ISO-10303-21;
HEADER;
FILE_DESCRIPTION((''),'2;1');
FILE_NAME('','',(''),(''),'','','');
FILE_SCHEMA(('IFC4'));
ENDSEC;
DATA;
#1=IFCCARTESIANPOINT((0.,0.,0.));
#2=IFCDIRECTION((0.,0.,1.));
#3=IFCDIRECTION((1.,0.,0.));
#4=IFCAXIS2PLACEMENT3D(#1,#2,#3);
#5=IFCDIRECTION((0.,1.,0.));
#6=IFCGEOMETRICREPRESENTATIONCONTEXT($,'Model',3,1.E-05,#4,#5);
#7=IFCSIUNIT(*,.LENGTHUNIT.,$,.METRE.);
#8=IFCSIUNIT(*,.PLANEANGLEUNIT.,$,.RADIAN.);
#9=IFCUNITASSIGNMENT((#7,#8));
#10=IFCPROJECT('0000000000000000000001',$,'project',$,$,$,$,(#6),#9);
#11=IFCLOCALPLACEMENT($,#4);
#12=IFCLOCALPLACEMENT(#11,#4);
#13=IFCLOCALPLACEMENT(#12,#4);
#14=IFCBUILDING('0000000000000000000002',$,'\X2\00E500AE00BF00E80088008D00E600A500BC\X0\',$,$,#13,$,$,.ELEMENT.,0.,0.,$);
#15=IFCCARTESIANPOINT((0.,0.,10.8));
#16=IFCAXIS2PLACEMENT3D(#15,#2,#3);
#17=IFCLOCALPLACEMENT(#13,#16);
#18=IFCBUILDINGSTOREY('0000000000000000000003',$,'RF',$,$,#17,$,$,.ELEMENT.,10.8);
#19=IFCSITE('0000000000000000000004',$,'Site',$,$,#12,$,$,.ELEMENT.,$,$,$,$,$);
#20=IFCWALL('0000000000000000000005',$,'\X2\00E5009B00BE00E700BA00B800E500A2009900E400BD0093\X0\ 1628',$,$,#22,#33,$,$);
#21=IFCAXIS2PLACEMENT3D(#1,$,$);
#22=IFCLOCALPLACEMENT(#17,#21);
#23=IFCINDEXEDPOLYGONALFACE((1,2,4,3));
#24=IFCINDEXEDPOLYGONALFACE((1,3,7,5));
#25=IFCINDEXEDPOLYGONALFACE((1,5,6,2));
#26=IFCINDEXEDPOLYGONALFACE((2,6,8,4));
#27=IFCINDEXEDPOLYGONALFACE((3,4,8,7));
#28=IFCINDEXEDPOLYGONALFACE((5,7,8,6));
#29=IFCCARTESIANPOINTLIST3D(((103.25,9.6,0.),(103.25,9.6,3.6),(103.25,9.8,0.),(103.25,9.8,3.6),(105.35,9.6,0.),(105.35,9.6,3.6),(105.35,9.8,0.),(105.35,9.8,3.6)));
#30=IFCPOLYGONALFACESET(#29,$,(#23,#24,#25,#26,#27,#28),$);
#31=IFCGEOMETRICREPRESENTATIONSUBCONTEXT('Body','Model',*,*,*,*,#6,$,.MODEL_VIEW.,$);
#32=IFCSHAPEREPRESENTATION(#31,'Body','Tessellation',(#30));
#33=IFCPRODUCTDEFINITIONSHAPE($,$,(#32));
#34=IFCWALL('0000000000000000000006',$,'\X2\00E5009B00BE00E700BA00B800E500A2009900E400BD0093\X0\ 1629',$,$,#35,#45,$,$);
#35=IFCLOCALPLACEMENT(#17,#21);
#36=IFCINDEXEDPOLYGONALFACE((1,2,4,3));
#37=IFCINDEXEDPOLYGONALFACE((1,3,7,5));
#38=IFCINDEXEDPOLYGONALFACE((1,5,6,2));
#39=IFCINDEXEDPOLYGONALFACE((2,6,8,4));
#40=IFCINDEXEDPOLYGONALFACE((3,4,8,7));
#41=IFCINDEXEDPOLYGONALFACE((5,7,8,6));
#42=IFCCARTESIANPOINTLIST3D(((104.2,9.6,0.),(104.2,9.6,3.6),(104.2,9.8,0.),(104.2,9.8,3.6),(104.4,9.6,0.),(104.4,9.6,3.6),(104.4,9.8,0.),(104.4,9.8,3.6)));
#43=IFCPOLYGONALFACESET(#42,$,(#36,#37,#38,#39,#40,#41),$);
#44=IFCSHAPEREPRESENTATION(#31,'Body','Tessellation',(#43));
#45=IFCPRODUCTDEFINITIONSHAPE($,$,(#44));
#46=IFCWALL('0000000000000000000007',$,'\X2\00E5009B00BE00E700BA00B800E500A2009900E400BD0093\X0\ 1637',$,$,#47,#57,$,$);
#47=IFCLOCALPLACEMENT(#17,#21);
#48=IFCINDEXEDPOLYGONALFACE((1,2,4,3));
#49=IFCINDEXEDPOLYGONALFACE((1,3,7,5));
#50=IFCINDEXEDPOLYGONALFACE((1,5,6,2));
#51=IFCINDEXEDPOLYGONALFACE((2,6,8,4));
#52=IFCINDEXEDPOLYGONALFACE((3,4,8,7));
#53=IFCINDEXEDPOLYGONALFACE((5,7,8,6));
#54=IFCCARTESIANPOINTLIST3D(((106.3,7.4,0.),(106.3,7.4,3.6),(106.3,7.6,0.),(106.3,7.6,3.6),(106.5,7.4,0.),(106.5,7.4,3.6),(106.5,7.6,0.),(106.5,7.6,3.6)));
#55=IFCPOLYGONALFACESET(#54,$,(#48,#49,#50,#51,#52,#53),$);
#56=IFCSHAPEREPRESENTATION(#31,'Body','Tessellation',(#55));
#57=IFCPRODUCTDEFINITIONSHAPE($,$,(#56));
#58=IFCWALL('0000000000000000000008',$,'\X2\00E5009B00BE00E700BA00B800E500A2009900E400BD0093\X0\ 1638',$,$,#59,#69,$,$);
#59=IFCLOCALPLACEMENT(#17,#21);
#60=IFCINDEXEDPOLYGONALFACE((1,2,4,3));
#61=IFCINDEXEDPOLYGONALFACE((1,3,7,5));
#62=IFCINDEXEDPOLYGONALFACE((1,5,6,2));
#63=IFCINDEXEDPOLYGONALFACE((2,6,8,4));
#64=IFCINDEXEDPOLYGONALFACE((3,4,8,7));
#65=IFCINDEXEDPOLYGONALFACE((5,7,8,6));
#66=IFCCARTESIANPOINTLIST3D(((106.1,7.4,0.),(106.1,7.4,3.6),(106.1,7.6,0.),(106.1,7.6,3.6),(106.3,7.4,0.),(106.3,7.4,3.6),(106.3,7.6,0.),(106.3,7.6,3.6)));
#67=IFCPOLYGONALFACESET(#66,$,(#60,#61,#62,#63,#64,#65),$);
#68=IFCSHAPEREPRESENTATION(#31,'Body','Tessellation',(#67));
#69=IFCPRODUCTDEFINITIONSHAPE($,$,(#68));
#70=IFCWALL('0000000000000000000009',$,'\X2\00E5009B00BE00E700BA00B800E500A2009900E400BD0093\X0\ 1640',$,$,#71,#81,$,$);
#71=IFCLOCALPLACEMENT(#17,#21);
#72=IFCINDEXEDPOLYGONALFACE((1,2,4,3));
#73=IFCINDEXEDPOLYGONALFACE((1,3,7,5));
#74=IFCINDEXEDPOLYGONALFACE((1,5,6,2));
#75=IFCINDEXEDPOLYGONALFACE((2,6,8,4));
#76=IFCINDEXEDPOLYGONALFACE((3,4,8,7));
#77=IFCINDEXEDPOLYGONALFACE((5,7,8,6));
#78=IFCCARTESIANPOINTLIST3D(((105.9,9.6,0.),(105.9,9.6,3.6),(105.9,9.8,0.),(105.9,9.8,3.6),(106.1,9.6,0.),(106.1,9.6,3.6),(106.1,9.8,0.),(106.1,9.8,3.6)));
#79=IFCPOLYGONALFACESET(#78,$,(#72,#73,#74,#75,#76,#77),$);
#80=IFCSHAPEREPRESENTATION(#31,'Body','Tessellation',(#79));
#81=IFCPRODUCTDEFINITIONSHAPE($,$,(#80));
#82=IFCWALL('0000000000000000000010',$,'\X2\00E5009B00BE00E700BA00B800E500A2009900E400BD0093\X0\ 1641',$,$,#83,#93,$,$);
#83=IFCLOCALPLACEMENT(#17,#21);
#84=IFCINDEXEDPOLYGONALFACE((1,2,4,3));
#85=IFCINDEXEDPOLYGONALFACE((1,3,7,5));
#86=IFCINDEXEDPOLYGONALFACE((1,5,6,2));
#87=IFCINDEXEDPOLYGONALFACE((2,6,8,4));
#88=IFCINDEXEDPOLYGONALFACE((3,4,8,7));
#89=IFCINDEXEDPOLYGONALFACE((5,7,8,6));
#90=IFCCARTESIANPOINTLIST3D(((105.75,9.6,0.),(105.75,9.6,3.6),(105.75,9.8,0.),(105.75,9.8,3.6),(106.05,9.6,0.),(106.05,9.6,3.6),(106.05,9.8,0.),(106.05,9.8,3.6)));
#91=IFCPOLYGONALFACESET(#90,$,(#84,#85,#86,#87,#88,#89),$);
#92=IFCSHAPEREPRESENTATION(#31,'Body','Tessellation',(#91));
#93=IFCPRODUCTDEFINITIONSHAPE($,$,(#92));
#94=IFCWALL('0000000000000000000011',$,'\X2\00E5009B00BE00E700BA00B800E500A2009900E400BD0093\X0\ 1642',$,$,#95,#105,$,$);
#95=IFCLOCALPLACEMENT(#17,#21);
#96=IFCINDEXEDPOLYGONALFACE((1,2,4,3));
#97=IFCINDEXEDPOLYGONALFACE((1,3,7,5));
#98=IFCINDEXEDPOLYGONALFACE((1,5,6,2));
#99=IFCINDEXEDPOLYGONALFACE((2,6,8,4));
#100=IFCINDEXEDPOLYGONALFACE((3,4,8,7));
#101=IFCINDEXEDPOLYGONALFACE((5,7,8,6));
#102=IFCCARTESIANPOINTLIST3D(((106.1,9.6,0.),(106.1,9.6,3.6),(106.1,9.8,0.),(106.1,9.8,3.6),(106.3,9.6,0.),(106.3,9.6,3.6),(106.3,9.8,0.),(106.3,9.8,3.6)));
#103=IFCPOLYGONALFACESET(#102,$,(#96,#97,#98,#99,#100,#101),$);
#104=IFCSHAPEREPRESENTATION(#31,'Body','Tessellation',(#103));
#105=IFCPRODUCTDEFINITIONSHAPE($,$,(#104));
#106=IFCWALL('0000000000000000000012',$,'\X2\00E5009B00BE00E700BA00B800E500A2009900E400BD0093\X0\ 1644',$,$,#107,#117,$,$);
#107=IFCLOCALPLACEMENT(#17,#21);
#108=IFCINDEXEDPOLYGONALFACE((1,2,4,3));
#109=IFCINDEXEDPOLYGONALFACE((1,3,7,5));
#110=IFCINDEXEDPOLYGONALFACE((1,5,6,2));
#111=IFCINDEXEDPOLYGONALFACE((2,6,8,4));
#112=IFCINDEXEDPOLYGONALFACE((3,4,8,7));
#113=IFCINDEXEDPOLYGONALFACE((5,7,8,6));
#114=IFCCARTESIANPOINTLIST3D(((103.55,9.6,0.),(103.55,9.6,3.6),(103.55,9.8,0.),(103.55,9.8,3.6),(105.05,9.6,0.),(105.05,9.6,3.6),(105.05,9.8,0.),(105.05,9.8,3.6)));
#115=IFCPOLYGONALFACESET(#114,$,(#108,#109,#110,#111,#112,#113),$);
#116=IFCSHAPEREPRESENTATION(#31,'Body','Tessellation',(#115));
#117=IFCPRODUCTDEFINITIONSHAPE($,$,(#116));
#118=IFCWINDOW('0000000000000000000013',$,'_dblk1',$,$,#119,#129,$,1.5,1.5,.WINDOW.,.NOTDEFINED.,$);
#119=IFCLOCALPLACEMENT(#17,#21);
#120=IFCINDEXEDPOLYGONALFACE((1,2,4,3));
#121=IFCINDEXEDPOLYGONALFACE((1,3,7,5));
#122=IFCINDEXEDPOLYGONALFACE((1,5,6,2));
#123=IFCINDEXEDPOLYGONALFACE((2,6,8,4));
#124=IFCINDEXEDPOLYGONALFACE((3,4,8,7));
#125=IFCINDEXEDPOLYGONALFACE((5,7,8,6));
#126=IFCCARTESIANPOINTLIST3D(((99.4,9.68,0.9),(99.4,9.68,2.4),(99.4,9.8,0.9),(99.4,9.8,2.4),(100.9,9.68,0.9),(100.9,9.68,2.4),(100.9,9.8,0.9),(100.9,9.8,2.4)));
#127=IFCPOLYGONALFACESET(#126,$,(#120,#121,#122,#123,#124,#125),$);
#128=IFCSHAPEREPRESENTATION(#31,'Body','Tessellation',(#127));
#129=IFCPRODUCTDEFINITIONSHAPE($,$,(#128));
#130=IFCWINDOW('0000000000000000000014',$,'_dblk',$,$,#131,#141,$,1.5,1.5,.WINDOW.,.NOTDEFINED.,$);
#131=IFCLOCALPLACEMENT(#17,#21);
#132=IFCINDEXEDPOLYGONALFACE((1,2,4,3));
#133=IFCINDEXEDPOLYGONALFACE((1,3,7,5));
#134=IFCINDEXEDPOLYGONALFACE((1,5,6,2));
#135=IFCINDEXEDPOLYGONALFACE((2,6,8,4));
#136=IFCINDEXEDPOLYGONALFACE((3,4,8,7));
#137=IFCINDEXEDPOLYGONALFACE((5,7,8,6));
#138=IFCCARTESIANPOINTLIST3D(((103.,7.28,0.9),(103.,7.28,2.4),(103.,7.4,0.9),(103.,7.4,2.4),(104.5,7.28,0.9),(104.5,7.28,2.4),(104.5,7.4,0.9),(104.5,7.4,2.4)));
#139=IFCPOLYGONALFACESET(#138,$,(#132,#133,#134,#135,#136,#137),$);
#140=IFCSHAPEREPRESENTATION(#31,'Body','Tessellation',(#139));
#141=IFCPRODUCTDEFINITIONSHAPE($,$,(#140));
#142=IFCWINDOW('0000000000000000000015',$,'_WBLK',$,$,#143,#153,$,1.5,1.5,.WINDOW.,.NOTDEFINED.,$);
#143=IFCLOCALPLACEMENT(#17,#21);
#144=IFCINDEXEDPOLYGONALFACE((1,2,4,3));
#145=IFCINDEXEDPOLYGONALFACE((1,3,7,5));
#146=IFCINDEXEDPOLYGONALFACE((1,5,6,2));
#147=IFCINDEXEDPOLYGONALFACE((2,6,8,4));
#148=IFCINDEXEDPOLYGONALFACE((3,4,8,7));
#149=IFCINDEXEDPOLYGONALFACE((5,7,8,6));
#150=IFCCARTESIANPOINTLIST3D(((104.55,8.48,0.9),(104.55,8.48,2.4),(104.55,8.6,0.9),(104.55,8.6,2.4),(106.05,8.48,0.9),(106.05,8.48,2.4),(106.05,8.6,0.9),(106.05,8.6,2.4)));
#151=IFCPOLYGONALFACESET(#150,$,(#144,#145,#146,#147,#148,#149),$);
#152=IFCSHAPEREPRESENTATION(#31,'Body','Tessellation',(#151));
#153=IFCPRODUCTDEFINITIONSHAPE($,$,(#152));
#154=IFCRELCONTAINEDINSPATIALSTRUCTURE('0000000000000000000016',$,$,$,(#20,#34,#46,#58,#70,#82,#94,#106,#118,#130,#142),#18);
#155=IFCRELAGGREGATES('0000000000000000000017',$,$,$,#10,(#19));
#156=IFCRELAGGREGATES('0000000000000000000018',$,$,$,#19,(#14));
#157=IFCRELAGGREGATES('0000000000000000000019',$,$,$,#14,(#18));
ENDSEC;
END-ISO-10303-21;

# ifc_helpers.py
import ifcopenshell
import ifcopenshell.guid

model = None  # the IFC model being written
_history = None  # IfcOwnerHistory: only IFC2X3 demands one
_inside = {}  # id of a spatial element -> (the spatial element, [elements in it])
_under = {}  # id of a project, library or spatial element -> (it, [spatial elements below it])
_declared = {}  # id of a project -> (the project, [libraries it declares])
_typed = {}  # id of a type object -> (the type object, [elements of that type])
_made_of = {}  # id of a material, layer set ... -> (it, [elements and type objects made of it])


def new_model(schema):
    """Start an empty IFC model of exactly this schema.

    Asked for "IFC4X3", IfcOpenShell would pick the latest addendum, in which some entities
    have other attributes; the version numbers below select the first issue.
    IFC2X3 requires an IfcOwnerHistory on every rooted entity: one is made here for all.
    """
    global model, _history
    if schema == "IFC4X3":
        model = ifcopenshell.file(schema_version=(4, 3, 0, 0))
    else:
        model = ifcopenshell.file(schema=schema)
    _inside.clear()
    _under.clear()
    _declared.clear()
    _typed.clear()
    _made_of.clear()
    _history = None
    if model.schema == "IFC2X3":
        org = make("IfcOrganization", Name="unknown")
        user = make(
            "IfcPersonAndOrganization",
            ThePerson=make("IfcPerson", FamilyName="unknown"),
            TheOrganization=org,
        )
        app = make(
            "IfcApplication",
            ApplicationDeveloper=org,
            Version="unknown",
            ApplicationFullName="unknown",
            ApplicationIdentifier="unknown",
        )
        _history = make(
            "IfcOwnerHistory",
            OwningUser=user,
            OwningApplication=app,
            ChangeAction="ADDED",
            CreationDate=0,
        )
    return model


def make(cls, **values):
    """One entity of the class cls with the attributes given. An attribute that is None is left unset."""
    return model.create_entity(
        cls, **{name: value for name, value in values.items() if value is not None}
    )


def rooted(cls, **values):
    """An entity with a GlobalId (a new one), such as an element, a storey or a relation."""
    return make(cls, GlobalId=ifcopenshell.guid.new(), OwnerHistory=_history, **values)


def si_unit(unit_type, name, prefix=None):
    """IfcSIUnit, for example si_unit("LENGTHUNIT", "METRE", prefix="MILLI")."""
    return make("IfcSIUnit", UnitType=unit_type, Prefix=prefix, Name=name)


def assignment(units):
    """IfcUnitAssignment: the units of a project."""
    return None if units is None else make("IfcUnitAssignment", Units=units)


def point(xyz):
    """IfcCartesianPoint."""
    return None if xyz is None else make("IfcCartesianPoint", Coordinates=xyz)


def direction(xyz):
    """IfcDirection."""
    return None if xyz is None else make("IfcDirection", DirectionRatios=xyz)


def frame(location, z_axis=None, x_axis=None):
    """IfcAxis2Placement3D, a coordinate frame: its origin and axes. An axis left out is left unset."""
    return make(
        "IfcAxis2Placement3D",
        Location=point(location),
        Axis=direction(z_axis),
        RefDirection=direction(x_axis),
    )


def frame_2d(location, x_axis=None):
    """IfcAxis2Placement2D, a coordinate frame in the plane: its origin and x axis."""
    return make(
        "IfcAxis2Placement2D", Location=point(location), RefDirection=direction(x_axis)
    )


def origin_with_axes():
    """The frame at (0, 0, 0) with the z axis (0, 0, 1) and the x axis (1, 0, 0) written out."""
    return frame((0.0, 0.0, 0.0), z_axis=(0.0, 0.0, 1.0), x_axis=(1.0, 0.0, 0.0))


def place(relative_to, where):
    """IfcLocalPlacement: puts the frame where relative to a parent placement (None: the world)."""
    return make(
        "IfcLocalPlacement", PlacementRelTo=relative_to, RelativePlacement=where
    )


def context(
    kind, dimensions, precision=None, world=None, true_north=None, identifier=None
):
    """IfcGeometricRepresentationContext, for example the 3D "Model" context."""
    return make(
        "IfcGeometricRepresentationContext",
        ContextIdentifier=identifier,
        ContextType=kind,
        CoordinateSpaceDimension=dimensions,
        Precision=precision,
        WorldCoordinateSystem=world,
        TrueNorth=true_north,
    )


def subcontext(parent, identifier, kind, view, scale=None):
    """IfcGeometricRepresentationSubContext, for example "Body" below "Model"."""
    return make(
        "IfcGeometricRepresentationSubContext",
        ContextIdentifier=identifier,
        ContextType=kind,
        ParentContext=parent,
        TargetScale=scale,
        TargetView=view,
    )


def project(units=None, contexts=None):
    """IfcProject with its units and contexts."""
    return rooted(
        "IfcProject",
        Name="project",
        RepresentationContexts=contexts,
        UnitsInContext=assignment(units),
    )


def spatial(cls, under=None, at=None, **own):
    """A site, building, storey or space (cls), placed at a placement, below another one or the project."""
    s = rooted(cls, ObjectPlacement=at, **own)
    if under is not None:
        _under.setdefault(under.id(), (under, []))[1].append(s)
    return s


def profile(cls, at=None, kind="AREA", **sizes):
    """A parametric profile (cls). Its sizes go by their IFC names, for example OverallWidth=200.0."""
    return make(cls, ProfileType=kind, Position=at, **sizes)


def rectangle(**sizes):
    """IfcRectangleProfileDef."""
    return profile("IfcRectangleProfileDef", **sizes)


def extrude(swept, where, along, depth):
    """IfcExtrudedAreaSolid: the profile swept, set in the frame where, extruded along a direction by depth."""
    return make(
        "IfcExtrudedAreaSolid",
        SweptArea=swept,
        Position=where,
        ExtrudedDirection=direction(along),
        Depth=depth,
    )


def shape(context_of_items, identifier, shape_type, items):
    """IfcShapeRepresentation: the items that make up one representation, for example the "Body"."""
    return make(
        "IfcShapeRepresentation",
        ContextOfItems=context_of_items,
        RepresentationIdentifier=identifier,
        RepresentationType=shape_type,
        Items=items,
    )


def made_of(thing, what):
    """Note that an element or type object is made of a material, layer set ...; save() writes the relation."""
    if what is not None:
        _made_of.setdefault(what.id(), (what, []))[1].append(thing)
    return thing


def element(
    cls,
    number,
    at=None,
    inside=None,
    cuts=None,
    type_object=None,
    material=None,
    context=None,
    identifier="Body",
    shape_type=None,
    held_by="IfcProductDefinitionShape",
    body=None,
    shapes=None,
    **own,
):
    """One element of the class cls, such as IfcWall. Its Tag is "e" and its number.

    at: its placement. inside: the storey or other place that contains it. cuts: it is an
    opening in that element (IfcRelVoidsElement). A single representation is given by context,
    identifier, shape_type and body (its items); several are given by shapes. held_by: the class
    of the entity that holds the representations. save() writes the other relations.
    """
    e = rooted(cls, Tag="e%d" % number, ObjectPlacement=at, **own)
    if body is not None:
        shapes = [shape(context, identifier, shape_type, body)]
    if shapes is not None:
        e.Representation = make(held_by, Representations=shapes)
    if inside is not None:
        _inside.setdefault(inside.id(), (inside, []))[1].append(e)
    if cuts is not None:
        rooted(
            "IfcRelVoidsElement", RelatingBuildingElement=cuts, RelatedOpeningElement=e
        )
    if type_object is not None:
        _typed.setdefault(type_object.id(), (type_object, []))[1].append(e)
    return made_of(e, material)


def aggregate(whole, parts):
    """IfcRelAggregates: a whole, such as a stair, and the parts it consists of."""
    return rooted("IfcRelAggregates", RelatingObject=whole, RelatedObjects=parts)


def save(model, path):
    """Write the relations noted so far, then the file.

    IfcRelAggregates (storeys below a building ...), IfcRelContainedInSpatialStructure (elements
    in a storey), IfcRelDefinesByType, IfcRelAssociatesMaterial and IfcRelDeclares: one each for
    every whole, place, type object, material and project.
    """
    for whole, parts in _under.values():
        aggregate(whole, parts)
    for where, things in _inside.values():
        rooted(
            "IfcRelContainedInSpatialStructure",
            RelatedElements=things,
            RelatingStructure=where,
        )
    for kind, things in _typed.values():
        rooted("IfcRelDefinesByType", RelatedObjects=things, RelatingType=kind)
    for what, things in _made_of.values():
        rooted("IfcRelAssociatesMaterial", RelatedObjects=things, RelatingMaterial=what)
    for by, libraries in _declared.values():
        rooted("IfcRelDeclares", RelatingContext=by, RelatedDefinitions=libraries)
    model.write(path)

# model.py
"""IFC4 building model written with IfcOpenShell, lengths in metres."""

from ifc_helpers import new_model, si_unit, direction, frame, frame_2d, origin_with_axes, place, context, subcontext, project, spatial, rectangle, extrude, element, save


model = new_model("IFC4")

# Units and contexts
model_context = context("Model", 3, precision=1e-05, world=origin_with_axes(), true_north=direction((0.0, 1.0, 0.0)))
body_context = subcontext(model_context, "Body", "Model", "MODEL_VIEW")
ifc_project = project(units=[si_unit("LENGTHUNIT", "METRE"), si_unit("PLANEANGLEUNIT", "RADIAN")], contexts=[model_context])

# Site, building, storey
placement = place(None, origin_with_axes())
site_placement = place(placement, origin_with_axes())
site = spatial("IfcSite", under=ifc_project, at=site_placement, Name="Site", CompositionType="ELEMENT")
building_placement = place(site_placement, origin_with_axes())
building = spatial("IfcBuilding", under=site, at=building_placement, Name="å®¿è\u0088\u008dæ¥¼", CompositionType="ELEMENT", ElevationOfRefHeight=0.0, ElevationOfTerrain=0.0)
storey_placement = place(building_placement, frame((0.0, 0.0, 10.8), z_axis=(0.0, 0.0, 1.0), x_axis=(1.0, 0.0, 0.0)))
storey = spatial("IfcBuildingStorey", under=building, at=storey_placement, Name="RF", CompositionType="ELEMENT", Elevation=10.8)

# Walls
wall_1_placement = place(storey_placement, frame((104.3, 9.7, 0.0), z_axis=(0.0, 0.0, 1.0), x_axis=(1.0, 0.0, 0.0)))
element("IfcWall", 1, at=wall_1_placement, inside=storey, Name="å\u009b¾çº¸å¢\u0099ä½\u0093 1628", context=body_context, shape_type="SweptSolid", body=[
    extrude(rectangle(XDim=2.1, YDim=0.2, at=frame_2d((0.0, 0.0), x_axis=(1.0, 0.0, 0.0))), frame((0.0, 0.0, 0.0), z_axis=(0.0, 0.0, 1.0)), (0.0, 0.0, 1.0), 3.6),
])
for number, where, z_axis, x_axis, name in (
    (2, (104.3, 9.7, 0.0), (0.0, 0.0, 1.0), (0.0, 1.0, 0.0), "å\u009b¾çº¸å¢\u0099ä½\u0093 1629"),
    (3, (106.4, 7.5, 0.0), (0.0, 0.0, 1.0), (0.0, -1.0, 0.0), "å\u009b¾çº¸å¢\u0099ä½\u0093 1637"),
    (4, (106.2, 7.5, 0.0), (0.0, 0.0, 1.0), (1.0, 0.0, 0.0), "å\u009b¾çº¸å¢\u0099ä½\u0093 1638"),
    (5, (106.0, 9.7, 0.0), (0.0, 0.0, 1.0), (-1.0, 0.0, 0.0), "å\u009b¾çº¸å¢\u0099ä½\u0093 1640"),
):
    element("IfcWall", number, at=place(storey_placement, frame(where, z_axis=z_axis, x_axis=x_axis)), inside=storey, Name=name, context=body_context, shape_type="SweptSolid", body=[
        extrude(rectangle(XDim=0.2, YDim=0.2, at=frame_2d((0.0, 0.0), x_axis=(1.0, 0.0, 0.0))), frame((0.0, 0.0, 0.0), z_axis=(0.0, 0.0, 1.0)), (0.0, 0.0, 1.0), 3.6),
    ])
wall_2_placement = place(storey_placement, frame((105.9, 9.7, 0.0), z_axis=(0.0, 0.0, 1.0), x_axis=(1.0, 0.0, 0.0)))
element("IfcWall", 6, at=wall_2_placement, inside=storey, Name="å\u009b¾çº¸å¢\u0099ä½\u0093 1641", context=body_context, shape_type="SweptSolid", body=[
    extrude(rectangle(XDim=0.3, YDim=0.2, at=frame_2d((0.0, 0.0), x_axis=(1.0, 0.0, 0.0))), frame((0.0, 0.0, 0.0), z_axis=(0.0, 0.0, 1.0)), (0.0, 0.0, 1.0), 3.6),
])
for number, where, z_axis, x_axis, name in (
    (7, (106.2, 9.7, 0.0), (0.0, 0.0, 1.0), (1.0, 0.0, 0.0), "å\u009b¾çº¸å¢\u0099ä½\u0093 1642"),
):
    element("IfcWall", number, at=place(storey_placement, frame(where, z_axis=z_axis, x_axis=x_axis)), inside=storey, Name=name, context=body_context, shape_type="SweptSolid", body=[
        extrude(rectangle(XDim=0.2, YDim=0.2, at=frame_2d((0.0, 0.0), x_axis=(1.0, 0.0, 0.0))), frame((0.0, 0.0, 0.0), z_axis=(0.0, 0.0, 1.0)), (0.0, 0.0, 1.0), 3.6),
    ])
wall_3_placement = place(storey_placement, frame((104.3, 9.7, 0.0), z_axis=(0.0, 0.0, 1.0), x_axis=(-1.0, 0.0, 0.0)))
element("IfcWall", 8, at=wall_3_placement, inside=storey, Name="å\u009b¾çº¸å¢\u0099ä½\u0093 1644", context=body_context, shape_type="SweptSolid", body=[
    extrude(rectangle(XDim=1.5, YDim=0.2, at=frame_2d((0.0, 0.0), x_axis=(1.0, 0.0, 0.0))), frame((0.0, 0.0, 0.0), z_axis=(0.0, 0.0, 1.0)), (0.0, 0.0, 1.0), 3.6),
])

# Windows
for number, where, z_axis, x_axis, name in (
    (9, (100.15, 9.74, 0.9), (0.0, 0.0, 1.0), (1.0, 0.0, 0.0), "_dblk1"),
    (10, (103.75, 7.34, 0.9), (0.0, 0.0, 1.0), (1.0, 0.0, 0.0), "_dblk"),
    (11, (105.3, 8.54, 0.9), (0.0, 0.0, 1.0), (1.0, 0.0, 0.0), "_WBLK"),
):
    element("IfcWindow", number, at=place(storey_placement, frame(where, z_axis=z_axis, x_axis=x_axis)), inside=storey, Name=name, OverallHeight=1.5, OverallWidth=1.5, PartitioningType="NOTDEFINED", PredefinedType="WINDOW", context=body_context, shape_type="SweptSolid", body=[
        extrude(rectangle(XDim=1.5, YDim=0.12, at=frame_2d((0.0, 0.0), x_axis=(1.0, 0.0, 0.0))), frame((0.0, 0.0, 0.0), z_axis=(0.0, 0.0, 1.0)), (0.0, 0.0, 1.0), 1.5),
    ])

save(model, "model.ifc")
